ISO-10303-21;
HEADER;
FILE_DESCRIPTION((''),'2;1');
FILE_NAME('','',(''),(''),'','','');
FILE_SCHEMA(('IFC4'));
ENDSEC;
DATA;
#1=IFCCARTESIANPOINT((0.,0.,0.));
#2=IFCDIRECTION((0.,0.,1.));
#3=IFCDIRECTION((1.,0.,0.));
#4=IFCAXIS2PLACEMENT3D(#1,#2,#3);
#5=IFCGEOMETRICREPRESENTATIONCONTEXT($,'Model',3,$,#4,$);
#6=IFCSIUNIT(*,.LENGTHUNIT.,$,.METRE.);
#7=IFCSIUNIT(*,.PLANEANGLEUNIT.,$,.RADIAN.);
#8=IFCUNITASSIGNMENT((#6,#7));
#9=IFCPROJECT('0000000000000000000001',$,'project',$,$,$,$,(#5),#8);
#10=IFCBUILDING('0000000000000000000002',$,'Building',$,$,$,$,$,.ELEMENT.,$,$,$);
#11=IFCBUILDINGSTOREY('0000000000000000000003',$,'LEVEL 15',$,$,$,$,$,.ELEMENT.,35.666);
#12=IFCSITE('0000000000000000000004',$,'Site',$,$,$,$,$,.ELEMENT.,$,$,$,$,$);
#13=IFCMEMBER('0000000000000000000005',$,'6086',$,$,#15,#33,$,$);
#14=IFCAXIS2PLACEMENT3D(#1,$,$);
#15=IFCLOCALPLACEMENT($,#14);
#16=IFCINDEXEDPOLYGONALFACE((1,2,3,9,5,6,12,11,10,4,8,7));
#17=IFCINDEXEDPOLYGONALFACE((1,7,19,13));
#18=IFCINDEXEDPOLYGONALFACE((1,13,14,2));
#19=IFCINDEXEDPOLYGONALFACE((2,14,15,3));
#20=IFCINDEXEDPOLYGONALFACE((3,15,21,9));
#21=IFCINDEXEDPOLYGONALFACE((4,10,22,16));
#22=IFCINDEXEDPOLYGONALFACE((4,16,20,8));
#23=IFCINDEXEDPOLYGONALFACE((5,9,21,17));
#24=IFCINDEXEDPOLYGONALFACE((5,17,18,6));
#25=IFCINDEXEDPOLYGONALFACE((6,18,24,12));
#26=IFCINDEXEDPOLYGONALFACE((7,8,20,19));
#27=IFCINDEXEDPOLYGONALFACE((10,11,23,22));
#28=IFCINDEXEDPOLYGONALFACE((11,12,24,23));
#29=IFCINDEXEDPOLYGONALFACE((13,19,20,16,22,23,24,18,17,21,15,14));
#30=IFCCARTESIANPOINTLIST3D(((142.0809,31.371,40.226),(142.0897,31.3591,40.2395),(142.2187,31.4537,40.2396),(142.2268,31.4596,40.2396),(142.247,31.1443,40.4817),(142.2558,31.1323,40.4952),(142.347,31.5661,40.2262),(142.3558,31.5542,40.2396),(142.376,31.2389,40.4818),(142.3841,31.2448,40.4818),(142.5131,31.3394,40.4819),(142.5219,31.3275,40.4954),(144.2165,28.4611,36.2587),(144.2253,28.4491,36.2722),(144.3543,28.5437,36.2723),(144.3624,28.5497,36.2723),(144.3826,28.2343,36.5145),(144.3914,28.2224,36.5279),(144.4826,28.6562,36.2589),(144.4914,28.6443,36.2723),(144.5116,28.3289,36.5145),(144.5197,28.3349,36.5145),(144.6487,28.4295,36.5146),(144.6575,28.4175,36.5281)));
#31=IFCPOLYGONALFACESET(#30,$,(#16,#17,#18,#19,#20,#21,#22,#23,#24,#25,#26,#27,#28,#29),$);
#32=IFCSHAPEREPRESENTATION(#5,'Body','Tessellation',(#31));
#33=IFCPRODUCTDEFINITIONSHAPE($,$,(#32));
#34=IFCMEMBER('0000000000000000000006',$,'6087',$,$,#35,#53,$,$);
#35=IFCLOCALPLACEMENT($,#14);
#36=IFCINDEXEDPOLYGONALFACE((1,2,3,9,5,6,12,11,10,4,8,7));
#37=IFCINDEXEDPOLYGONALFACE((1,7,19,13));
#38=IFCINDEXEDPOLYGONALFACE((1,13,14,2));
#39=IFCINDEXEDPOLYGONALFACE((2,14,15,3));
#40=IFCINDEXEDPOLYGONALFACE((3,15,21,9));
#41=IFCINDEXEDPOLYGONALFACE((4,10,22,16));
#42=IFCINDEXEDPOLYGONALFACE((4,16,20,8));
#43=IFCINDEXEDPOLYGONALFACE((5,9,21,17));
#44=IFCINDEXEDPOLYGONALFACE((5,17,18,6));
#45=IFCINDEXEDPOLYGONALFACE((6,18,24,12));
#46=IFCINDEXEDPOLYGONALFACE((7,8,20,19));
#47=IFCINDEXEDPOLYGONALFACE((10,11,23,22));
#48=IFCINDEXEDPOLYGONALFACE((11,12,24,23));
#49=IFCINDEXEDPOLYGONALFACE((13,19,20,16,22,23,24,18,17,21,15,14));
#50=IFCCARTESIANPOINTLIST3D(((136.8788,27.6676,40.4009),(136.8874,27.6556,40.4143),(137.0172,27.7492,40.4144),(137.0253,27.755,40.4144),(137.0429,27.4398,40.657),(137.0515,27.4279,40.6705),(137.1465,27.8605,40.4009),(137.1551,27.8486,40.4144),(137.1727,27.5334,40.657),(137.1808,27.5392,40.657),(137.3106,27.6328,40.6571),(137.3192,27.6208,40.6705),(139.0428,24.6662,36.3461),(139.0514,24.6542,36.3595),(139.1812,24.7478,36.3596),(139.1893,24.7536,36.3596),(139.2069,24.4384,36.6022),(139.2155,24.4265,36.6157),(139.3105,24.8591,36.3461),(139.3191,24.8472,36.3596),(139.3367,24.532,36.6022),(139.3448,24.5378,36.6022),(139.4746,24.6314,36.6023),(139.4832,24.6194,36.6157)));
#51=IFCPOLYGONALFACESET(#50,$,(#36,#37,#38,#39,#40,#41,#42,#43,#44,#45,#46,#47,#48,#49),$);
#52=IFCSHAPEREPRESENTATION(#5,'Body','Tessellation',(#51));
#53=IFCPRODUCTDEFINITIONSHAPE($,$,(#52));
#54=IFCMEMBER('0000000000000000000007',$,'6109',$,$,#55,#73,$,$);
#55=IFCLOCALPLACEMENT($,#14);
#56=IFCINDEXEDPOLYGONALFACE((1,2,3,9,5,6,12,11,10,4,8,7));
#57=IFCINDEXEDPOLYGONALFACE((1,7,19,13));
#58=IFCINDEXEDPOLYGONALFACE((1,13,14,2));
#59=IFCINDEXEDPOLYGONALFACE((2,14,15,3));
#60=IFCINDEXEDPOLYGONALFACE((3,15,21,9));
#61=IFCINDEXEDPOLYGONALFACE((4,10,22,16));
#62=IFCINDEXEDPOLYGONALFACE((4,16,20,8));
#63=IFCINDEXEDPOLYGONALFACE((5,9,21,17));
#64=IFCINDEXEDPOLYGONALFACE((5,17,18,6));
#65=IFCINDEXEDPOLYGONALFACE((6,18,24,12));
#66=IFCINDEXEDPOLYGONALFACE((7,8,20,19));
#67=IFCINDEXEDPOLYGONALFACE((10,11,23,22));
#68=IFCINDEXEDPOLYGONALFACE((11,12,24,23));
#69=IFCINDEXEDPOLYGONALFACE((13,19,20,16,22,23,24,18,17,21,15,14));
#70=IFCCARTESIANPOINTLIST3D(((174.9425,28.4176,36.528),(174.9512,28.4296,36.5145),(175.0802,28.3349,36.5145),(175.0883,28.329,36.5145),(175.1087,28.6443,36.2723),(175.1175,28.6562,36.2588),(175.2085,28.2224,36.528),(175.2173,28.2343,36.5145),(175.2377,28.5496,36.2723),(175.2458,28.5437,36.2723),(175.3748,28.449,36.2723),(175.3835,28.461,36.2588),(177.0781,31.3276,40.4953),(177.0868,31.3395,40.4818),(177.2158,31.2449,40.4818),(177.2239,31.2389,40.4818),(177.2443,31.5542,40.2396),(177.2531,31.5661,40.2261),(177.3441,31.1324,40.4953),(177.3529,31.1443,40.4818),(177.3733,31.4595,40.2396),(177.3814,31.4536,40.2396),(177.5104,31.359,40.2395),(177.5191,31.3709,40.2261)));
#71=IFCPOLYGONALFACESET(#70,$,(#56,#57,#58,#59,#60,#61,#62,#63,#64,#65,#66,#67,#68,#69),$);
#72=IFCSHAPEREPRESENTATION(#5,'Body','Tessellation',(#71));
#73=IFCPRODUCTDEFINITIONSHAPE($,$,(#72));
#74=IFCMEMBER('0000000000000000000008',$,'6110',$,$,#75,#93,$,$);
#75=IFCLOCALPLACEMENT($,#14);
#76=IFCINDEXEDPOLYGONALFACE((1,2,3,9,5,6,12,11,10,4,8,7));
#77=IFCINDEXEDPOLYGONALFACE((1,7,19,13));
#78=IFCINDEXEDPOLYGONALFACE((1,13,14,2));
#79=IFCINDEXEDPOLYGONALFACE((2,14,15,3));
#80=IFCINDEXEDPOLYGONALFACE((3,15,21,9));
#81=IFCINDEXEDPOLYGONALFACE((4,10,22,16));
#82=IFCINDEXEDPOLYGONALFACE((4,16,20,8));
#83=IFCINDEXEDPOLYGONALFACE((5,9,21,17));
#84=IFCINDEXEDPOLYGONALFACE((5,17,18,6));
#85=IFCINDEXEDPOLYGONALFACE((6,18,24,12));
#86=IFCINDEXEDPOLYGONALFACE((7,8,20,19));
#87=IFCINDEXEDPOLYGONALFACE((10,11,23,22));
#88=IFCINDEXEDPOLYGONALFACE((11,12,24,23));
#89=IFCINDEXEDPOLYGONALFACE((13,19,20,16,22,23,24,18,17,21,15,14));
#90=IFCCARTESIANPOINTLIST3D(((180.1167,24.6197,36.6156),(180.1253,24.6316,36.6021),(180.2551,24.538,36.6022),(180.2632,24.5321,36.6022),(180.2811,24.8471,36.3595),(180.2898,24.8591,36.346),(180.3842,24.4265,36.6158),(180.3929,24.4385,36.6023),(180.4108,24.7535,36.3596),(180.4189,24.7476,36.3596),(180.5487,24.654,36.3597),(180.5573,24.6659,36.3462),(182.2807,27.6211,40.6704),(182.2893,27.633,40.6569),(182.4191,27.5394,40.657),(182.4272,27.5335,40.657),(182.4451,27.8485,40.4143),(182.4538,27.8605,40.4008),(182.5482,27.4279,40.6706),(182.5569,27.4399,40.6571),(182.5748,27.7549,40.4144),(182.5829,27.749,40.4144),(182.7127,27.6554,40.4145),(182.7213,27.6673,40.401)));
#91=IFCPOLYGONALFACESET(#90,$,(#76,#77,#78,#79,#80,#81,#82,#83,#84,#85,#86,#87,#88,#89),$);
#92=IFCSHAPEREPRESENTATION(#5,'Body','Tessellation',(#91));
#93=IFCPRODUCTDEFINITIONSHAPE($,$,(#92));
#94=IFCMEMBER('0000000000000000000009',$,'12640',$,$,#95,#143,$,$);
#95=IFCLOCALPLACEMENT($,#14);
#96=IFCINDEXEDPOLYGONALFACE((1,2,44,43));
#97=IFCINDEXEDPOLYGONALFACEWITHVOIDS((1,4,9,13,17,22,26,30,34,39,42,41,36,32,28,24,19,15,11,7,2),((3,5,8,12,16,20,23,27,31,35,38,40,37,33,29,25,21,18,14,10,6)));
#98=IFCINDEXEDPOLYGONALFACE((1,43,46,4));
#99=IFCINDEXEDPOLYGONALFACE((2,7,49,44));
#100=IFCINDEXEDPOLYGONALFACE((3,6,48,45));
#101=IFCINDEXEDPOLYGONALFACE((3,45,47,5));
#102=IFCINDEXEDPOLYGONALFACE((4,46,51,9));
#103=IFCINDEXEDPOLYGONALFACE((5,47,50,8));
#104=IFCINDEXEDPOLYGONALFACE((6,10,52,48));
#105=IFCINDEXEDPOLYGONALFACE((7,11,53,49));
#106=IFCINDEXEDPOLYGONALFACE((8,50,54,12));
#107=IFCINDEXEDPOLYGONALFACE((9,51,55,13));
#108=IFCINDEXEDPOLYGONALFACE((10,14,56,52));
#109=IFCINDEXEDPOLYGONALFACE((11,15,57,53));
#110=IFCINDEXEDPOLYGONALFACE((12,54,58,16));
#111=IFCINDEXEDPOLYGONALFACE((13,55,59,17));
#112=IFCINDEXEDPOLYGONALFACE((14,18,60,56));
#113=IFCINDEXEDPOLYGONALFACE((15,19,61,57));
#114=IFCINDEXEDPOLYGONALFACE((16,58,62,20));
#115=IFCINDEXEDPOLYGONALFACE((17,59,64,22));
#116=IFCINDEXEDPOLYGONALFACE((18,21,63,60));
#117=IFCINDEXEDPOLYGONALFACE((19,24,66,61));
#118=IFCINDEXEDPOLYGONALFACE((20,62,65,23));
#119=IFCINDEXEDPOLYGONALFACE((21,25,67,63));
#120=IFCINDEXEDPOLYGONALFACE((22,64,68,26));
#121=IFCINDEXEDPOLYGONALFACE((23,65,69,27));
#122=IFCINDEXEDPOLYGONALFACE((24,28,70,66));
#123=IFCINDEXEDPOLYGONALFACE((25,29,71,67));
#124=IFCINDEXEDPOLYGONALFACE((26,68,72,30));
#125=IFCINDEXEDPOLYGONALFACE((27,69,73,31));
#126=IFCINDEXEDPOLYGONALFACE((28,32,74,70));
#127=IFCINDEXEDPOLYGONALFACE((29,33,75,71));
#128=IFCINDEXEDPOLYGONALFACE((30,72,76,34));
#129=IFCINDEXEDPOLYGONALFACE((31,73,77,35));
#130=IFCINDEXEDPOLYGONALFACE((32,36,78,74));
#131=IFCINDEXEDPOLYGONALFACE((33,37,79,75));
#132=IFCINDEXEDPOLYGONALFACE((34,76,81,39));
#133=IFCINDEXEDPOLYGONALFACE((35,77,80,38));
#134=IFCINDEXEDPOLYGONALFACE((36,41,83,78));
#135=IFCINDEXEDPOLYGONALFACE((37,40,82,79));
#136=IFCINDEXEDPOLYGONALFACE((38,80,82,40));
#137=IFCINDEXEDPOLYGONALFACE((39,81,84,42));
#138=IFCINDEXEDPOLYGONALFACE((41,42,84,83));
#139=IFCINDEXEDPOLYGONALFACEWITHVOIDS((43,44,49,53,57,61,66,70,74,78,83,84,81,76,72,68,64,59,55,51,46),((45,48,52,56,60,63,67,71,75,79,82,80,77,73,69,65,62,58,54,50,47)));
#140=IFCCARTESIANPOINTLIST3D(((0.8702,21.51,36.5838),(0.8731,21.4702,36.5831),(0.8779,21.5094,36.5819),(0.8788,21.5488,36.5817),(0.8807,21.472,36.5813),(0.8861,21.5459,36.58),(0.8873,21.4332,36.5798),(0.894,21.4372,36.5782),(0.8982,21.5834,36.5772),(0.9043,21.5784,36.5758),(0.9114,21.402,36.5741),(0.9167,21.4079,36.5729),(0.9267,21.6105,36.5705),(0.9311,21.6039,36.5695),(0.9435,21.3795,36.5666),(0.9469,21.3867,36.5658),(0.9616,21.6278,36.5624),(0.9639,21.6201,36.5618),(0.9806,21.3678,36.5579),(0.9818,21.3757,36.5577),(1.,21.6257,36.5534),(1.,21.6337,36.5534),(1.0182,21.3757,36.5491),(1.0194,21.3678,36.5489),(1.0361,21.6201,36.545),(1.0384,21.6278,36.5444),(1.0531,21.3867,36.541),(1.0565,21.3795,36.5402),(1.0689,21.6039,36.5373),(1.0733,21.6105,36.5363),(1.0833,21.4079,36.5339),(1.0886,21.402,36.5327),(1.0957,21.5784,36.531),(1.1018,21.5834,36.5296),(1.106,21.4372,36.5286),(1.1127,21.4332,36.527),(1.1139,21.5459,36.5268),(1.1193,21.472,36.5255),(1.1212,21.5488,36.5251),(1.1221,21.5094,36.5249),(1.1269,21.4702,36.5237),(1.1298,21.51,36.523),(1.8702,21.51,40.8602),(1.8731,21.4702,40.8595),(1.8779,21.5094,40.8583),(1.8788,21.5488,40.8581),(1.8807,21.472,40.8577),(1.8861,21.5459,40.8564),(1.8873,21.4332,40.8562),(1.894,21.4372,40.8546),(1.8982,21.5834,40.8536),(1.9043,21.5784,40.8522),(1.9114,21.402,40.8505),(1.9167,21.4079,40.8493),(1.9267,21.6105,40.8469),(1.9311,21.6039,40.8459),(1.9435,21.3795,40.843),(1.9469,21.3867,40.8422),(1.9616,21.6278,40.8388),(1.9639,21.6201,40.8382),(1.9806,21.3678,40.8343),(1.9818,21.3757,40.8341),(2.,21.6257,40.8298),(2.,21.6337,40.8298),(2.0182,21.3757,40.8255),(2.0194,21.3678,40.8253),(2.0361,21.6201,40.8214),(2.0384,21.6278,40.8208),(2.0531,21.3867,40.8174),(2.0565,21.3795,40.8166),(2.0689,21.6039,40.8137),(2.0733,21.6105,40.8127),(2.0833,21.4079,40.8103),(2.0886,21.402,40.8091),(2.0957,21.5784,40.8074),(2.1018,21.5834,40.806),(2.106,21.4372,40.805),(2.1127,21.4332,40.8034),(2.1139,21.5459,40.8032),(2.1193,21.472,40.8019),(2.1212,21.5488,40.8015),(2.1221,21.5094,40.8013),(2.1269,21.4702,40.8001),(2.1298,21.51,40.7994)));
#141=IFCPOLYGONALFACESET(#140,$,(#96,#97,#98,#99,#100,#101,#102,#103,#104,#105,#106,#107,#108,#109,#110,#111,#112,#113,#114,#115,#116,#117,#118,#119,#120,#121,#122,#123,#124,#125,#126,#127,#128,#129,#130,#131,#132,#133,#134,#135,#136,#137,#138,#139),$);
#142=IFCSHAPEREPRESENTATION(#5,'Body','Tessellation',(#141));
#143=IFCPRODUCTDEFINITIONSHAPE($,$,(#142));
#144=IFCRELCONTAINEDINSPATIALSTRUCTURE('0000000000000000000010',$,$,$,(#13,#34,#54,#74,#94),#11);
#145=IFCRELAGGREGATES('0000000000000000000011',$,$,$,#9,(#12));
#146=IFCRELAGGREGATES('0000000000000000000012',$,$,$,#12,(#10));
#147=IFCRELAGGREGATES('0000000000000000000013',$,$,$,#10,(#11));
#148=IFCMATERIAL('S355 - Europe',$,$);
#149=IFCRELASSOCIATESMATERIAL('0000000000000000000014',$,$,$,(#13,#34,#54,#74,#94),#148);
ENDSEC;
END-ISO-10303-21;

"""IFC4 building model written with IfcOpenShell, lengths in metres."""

from ifc_helpers import new_model, si_unit, frame, origin_with_axes, origin_2d_with_axis, place, context, project, spatial, hollow_circle, i_section, extrude, material, material_profile, profile_set, profile_usage, element, save


model = new_model("IFC4")

# Units and contexts
model_context = context("Model", 3, world=origin_with_axes())
ifc_project = project(units=[si_unit("LENGTHUNIT", "METRE"), si_unit("PLANEANGLEUNIT", "RADIAN")], contexts=[model_context])

# Site, building, storey
site = spatial("IfcSite", under=ifc_project, Name="Site", CompositionType="ELEMENT")
building = spatial("IfcBuilding", under=site, Name="Building", CompositionType="ELEMENT")
storey = spatial("IfcBuildingStorey", under=building, Name="LEVEL 15", CompositionType="ELEMENT", Elevation=35.666)

# Shared definitions
ifc_material = material(Name="S355 - Europe")

# Members
ifc_material_profile_1 = material_profile(ifc_material, i_section(OverallWidth=0.33, OverallDepth=0.4, WebThickness=0.01, FlangeThickness=0.02, at=origin_2d_with_axis()))
ifc_profile_set_1 = profile_set([ifc_material_profile_1])
ifc_profile_usage_1 = profile_usage(ifc_profile_set_1, cardinal=10)
member_1_placement = place(None, frame((144.437, 28.4393, 36.3934), z_axis=(-0.398167, 0.542538, 0.739673), x_axis=(-0.806706, -0.590953, 0.0)))
element("IfcMember", 1, at=member_1_placement, inside=storey, material=ifc_profile_usage_1, Name="6086", context=model_context, shape_type="SweptSolid", body=[
    extrude(i_section(OverallWidth=0.33, OverallDepth=0.4, WebThickness=0.01, FlangeThickness=0.02, at=origin_2d_with_axis()), origin_with_axes(), (0.0, 0.0, 1.0), 5.3636),
])
ifc_material_profile_2 = material_profile(ifc_material, i_section(OverallWidth=0.33, OverallDepth=0.4, WebThickness=0.01, FlangeThickness=0.02, at=origin_2d_with_axis()))
ifc_profile_set_2 = profile_set([ifc_material_profile_2])
ifc_profile_usage_2 = profile_usage(ifc_profile_set_2, cardinal=10)
member_2_placement = place(None, frame((139.263, 24.6428, 36.4809), z_axis=(-0.39422, 0.54677, 0.73867), x_axis=(-0.811322, -0.584599, 0.0)))
element("IfcMember", 2, at=member_2_placement, inside=storey, material=ifc_profile_usage_2, Name="6087", context=model_context, shape_type="SweptSolid", body=[
    extrude(i_section(OverallWidth=0.33, OverallDepth=0.4, WebThickness=0.01, FlangeThickness=0.02, at=origin_2d_with_axis()), origin_with_axes(), (0.0, 0.0, 1.0), 5.4893),
])
ifc_material_profile_3 = material_profile(ifc_material, i_section(OverallWidth=0.33, OverallDepth=0.4, WebThickness=0.01, FlangeThickness=0.02, at=origin_2d_with_axis()))
ifc_profile_set_3 = profile_set([ifc_material_profile_3])
ifc_profile_usage_3 = profile_usage(ifc_profile_set_3, cardinal=10)
member_3_placement = place(None, frame((175.163, 28.4393, 36.3934), z_axis=(0.398167, 0.542538, 0.739673), x_axis=(-0.806237, 0.591593, 0.0)))
element("IfcMember", 3, at=member_3_placement, inside=storey, material=ifc_profile_usage_3, Name="6109", context=model_context, shape_type="SweptSolid", body=[
    extrude(i_section(OverallWidth=0.33, OverallDepth=0.4, WebThickness=0.01, FlangeThickness=0.02, at=origin_2d_with_axis()), origin_with_axes(), (0.0, 0.0, 1.0), 5.3636),
])
ifc_material_profile_4 = material_profile(ifc_material, i_section(OverallWidth=0.33, OverallDepth=0.4, WebThickness=0.01, FlangeThickness=0.02, at=origin_2d_with_axis()))
ifc_profile_set_4 = profile_set([ifc_material_profile_4])
ifc_profile_usage_4 = profile_usage(ifc_profile_set_4, cardinal=10)
member_4_placement = place(None, frame((180.337, 24.6428, 36.4809), z_axis=(0.39422, 0.54677, 0.73867), x_axis=(-0.810441, 0.585821, 0.0)))
element("IfcMember", 4, at=member_4_placement, inside=storey, material=ifc_profile_usage_4, Name="6110", context=model_context, shape_type="SweptSolid", body=[
    extrude(i_section(OverallWidth=0.33, OverallDepth=0.4, WebThickness=0.01, FlangeThickness=0.02, at=origin_2d_with_axis()), origin_with_axes(), (0.0, 0.0, 1.0), 5.4893),
])
ifc_material_profile_5 = material_profile(ifc_material, hollow_circle(Radius=0.1337, WallThickness=0.008, at=origin_2d_with_axis()))
ifc_profile_set_5 = profile_set([ifc_material_profile_5])
ifc_profile_usage_5 = profile_usage(ifc_profile_set_5, cardinal=10)
member_5_placement = place(None, frame((1.0, 21.5, 36.5534), z_axis=(0.227699, 0.0, 0.973732), x_axis=(0.0, 1.0, 0.0)))
element("IfcMember", 5, at=member_5_placement, inside=storey, material=ifc_profile_usage_5, Name="12640", context=model_context, shape_type="SweptSolid", body=[
    extrude(hollow_circle(Radius=0.1337, WallThickness=0.008, at=origin_2d_with_axis()), origin_with_axes(), (0.0, 0.0, 1.0), 4.3918),
])

save(model, "model.ifc")
